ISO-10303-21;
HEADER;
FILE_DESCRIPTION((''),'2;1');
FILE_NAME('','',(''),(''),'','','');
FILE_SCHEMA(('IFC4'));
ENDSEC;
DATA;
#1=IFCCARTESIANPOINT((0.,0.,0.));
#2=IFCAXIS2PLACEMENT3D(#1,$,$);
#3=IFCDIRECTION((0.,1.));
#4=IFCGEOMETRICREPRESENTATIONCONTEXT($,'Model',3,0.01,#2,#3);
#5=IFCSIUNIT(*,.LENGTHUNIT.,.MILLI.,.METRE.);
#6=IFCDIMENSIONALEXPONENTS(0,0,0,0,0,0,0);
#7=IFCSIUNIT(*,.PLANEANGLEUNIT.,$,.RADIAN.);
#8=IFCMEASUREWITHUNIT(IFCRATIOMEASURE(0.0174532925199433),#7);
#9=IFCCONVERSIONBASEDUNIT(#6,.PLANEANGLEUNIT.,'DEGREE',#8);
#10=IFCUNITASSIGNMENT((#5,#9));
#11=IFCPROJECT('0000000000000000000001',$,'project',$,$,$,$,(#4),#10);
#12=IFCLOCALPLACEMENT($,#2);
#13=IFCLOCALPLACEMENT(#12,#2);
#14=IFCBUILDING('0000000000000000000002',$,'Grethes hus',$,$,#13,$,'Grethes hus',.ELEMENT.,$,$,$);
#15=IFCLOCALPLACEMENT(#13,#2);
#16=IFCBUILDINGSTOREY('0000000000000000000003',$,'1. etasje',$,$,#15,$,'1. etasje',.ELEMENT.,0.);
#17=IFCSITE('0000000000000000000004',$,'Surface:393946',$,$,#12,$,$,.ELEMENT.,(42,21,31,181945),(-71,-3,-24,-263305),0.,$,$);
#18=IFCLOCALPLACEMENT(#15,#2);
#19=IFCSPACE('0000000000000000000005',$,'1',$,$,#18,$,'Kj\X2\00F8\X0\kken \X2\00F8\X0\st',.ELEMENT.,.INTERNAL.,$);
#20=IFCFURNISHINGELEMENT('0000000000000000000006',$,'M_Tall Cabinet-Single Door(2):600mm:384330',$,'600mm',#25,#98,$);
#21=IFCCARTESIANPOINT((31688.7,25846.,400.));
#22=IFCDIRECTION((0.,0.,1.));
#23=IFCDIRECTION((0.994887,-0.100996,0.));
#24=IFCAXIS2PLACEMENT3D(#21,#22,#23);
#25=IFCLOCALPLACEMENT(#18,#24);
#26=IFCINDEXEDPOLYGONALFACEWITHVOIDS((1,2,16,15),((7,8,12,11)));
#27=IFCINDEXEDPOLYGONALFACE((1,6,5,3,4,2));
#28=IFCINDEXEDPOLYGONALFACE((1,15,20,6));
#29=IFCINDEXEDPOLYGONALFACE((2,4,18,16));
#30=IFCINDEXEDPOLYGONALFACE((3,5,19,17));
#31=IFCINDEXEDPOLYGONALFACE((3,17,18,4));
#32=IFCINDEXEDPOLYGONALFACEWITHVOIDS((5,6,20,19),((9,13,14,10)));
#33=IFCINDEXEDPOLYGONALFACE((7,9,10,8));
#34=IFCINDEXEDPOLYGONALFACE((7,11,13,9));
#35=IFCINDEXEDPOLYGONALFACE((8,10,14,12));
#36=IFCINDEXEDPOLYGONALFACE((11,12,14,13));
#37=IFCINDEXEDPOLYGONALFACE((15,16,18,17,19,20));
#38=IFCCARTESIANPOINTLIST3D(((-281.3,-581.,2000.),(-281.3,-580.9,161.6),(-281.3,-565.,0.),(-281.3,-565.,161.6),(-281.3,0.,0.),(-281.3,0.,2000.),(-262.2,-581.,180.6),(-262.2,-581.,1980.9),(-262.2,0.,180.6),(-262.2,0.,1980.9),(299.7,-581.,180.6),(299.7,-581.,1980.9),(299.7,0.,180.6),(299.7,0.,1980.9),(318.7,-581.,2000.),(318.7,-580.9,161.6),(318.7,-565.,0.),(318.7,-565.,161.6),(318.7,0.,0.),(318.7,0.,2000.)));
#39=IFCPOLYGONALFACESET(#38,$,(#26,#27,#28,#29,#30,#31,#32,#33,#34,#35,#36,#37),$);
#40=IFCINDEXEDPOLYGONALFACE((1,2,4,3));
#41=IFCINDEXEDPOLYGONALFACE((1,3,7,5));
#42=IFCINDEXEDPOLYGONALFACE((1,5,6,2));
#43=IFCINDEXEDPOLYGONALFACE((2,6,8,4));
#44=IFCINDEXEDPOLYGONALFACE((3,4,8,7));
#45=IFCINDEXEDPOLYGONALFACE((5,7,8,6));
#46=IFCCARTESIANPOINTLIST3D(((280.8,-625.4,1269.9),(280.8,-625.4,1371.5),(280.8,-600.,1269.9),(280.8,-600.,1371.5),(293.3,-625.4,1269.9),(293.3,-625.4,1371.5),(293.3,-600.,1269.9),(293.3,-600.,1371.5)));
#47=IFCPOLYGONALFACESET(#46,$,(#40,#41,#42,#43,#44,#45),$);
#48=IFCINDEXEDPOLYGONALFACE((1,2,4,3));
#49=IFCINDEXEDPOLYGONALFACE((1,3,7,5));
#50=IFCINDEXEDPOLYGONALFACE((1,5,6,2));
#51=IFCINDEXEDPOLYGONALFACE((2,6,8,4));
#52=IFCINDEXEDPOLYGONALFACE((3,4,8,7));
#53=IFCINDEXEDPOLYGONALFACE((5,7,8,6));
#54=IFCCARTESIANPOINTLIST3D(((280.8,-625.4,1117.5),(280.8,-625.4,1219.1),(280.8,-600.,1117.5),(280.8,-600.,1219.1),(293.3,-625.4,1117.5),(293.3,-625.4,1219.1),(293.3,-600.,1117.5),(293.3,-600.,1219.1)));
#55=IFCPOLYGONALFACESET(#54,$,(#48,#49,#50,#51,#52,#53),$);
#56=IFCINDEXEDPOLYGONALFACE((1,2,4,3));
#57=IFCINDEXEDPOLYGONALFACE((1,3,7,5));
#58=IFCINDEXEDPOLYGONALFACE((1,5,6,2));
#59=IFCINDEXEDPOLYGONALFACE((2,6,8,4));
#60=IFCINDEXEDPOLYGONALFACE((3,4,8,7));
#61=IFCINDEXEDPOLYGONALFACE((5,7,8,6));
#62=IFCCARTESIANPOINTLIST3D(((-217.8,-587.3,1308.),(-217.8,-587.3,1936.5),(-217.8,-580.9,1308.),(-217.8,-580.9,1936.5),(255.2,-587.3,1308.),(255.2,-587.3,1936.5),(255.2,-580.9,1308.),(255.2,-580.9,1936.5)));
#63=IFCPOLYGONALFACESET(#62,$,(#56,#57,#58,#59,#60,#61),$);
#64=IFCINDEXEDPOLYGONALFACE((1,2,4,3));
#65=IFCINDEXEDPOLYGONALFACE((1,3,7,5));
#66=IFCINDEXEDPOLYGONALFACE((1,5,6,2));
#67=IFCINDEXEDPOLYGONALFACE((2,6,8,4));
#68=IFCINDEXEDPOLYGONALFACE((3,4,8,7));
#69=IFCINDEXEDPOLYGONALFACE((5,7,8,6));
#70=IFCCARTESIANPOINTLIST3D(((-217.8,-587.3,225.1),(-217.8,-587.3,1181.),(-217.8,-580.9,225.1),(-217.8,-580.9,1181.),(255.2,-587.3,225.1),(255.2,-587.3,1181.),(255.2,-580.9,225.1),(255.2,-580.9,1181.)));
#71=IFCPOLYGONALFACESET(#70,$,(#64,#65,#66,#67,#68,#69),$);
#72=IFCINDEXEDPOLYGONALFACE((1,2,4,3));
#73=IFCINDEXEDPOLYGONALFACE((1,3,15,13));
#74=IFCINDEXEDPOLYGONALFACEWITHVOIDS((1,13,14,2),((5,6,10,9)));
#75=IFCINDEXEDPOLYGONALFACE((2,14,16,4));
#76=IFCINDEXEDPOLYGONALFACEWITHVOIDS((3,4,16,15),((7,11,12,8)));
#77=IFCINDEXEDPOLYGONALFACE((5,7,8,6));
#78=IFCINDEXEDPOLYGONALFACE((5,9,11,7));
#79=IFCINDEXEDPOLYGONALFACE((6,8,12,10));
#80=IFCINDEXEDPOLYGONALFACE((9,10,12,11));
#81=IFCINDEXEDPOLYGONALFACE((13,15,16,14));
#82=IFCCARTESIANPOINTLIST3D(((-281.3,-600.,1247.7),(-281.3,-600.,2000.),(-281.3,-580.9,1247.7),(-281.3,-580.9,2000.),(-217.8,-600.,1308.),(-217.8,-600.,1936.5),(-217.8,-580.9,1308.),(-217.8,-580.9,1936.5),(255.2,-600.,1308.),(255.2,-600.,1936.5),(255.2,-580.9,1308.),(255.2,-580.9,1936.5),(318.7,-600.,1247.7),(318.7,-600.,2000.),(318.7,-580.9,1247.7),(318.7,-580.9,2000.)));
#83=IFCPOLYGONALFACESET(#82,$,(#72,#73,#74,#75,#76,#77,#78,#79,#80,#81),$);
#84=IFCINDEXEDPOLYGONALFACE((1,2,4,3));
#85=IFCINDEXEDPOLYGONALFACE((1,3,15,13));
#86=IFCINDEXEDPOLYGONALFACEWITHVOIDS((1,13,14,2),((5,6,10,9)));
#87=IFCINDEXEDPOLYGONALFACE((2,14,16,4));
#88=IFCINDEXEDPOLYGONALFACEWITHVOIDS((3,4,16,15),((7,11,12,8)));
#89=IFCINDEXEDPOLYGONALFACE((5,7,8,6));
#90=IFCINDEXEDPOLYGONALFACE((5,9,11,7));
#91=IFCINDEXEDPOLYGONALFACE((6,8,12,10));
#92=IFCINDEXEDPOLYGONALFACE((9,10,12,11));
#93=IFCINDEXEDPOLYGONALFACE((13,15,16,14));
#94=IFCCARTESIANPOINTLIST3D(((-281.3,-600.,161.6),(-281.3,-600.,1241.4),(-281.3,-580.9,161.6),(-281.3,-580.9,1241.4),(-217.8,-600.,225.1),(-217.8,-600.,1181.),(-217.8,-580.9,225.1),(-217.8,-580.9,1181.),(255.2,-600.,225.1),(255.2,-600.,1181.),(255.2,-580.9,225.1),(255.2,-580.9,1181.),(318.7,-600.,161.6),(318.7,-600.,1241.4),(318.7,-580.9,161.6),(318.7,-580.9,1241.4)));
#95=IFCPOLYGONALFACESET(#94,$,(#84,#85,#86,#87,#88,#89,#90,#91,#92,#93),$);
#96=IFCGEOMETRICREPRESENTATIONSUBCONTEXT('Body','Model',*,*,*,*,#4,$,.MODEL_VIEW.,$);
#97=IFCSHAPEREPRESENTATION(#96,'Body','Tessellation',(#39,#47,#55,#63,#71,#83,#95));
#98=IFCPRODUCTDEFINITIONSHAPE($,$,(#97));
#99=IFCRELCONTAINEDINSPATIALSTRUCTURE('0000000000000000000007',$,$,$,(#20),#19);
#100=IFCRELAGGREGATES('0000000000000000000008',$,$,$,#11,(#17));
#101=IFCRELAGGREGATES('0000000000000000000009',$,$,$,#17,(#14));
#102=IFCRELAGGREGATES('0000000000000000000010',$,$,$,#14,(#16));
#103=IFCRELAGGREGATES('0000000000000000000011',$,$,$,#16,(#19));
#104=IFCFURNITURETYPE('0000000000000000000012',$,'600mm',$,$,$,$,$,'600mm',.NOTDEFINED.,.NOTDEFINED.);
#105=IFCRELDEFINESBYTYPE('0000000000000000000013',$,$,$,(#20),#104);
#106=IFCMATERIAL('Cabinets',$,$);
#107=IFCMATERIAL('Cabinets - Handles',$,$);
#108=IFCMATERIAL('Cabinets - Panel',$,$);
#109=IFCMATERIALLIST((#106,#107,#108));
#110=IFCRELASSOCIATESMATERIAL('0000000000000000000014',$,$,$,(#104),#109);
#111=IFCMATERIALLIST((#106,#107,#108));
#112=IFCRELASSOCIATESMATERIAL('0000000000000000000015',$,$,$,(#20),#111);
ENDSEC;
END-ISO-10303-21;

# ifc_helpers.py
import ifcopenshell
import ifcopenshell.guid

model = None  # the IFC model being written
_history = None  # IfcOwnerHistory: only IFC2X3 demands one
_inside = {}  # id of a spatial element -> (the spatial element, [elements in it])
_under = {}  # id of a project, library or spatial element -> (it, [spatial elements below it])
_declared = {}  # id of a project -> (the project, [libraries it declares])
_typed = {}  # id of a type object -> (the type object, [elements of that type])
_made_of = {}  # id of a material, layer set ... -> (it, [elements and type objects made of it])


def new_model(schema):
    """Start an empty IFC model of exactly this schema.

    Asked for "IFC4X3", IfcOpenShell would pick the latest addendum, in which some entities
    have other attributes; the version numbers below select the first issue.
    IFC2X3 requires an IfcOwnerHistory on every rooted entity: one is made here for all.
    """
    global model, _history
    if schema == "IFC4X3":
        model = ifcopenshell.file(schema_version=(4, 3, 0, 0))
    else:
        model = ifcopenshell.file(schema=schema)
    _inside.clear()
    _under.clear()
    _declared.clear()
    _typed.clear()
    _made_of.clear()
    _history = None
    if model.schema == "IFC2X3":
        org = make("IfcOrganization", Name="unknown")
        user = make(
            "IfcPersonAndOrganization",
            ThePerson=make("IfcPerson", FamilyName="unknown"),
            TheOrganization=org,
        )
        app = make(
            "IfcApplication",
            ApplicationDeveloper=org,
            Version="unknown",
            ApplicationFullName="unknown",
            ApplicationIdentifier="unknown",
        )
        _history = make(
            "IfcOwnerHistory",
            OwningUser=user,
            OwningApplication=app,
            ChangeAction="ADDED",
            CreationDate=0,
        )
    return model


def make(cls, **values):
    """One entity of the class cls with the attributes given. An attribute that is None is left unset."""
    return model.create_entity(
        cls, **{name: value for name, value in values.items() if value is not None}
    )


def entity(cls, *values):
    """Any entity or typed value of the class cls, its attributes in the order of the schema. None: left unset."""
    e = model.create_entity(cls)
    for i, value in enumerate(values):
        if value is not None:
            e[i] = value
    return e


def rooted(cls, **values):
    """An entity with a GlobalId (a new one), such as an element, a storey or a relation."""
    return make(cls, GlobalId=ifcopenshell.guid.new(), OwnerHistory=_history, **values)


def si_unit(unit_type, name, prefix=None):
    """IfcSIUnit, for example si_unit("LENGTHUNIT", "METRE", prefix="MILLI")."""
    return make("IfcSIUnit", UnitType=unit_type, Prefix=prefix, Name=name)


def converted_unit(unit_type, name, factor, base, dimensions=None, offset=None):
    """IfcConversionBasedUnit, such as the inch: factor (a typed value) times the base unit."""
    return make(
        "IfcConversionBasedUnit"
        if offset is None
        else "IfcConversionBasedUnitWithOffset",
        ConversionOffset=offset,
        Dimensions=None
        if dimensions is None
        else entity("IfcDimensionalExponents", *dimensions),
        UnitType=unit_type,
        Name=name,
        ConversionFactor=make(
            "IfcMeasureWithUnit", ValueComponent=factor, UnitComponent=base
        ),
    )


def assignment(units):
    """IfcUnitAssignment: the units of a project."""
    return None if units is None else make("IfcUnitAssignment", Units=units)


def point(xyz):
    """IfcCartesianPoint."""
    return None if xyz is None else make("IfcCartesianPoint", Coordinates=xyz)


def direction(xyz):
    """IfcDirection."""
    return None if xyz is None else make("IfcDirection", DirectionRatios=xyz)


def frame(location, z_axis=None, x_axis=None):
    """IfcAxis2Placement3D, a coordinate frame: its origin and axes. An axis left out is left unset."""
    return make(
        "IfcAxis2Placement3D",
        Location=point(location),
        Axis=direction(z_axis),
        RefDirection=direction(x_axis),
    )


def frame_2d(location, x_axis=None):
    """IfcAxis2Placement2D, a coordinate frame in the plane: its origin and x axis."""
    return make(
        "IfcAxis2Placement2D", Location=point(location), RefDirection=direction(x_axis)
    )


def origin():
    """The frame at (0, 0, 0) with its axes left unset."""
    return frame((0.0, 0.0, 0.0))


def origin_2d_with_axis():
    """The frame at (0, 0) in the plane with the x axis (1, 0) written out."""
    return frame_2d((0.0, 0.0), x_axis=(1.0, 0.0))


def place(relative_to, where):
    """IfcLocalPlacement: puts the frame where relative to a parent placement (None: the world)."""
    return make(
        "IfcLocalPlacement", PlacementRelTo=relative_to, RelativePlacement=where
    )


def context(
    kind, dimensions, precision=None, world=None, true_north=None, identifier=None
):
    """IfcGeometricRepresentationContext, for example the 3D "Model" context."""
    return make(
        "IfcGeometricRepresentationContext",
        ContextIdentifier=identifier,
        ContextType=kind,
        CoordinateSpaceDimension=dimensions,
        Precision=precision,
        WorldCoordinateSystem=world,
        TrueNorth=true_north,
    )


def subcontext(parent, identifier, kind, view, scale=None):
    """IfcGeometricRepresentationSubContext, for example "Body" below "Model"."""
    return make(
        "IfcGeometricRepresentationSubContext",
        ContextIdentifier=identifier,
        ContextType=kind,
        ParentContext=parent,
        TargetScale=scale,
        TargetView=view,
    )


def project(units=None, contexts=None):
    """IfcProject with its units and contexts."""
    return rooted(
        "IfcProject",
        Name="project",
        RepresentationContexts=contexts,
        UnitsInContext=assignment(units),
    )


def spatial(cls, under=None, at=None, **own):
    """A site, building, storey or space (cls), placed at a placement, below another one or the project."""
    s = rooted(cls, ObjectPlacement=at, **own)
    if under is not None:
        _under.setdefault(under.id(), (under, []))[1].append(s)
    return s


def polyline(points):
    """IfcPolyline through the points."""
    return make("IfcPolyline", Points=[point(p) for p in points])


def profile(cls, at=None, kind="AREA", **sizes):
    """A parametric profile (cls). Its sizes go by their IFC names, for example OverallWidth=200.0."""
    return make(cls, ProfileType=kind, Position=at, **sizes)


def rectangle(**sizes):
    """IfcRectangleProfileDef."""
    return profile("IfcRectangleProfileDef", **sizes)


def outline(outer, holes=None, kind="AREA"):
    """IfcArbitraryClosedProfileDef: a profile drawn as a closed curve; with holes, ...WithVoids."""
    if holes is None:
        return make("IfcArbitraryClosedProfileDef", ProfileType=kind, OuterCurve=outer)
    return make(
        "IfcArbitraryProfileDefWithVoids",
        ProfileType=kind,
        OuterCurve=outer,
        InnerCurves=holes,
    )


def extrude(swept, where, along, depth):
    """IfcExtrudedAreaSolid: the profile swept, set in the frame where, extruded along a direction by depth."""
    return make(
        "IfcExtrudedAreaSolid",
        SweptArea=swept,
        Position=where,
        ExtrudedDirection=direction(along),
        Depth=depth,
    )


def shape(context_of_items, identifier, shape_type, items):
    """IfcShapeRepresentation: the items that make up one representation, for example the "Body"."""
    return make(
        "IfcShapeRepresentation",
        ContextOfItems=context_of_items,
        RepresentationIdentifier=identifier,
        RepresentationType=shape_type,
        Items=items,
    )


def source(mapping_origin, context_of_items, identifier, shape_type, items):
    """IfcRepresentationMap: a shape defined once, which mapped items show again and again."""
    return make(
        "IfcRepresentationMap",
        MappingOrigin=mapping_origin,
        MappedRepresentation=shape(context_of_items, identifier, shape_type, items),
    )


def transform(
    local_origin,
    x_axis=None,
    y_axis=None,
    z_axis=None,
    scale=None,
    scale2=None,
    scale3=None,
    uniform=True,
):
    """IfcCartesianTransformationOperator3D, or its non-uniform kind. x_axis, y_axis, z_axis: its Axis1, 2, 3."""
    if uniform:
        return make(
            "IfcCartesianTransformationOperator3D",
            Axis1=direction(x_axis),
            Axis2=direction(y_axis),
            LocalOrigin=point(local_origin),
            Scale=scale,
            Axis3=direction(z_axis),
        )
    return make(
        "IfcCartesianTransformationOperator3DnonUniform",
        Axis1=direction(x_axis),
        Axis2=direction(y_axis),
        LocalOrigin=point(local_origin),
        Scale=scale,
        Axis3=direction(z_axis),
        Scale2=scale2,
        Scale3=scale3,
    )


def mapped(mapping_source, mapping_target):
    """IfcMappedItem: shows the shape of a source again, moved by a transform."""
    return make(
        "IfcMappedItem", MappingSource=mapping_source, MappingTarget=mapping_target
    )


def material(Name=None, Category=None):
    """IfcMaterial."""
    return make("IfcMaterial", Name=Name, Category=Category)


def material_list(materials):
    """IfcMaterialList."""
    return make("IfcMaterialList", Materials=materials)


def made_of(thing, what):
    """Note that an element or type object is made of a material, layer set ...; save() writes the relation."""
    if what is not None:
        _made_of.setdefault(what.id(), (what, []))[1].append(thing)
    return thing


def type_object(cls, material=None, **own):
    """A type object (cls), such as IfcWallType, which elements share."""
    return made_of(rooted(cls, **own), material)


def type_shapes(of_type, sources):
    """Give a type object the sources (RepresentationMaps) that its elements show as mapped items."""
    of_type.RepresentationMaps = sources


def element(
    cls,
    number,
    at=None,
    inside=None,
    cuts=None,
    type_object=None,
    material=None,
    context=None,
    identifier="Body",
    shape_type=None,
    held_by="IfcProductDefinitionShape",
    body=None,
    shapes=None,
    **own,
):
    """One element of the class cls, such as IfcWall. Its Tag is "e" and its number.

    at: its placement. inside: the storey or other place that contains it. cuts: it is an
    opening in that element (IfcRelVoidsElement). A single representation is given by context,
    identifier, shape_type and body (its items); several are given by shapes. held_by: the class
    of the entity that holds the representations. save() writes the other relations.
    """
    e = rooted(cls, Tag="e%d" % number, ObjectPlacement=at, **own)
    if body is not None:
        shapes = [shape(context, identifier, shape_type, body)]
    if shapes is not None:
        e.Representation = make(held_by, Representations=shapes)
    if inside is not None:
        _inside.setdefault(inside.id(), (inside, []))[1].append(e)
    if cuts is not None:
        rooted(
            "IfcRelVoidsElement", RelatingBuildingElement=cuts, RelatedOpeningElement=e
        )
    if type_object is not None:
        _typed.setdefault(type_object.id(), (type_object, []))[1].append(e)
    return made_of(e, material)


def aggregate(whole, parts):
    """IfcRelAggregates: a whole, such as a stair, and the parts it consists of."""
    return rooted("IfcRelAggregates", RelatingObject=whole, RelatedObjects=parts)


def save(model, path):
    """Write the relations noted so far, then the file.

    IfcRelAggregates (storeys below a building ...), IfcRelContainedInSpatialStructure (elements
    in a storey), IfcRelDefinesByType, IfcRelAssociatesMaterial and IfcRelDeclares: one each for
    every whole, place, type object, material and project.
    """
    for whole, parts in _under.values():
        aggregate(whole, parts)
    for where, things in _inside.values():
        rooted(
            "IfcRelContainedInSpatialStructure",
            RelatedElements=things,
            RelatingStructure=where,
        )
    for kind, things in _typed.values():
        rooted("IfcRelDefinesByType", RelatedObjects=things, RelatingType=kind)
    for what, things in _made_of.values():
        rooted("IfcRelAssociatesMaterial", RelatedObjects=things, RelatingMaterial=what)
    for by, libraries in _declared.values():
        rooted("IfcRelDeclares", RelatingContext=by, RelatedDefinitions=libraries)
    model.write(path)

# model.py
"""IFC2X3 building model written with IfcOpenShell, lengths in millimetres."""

from ifc_helpers import new_model, entity, si_unit, converted_unit, direction, frame, frame_2d, origin, origin_2d_with_axis, place, context, subcontext, project, spatial, polyline, rectangle, outline, extrude, source, transform, mapped, material, material_list, type_object, type_shapes, element, save


model = new_model("IFC2X3")

# Units and contexts
model_context = context("Model", 3, precision=0.01, world=origin(), true_north=direction((0.0, 1.0)))
body_context = subcontext(model_context, "Body", "Model", "MODEL_VIEW")
ifc_project = project(units=[si_unit("LENGTHUNIT", "METRE", prefix="MILLI"), converted_unit("PLANEANGLEUNIT", "DEGREE", entity("IfcRatioMeasure", 0.0174532925199433), si_unit("PLANEANGLEUNIT", "RADIAN"), dimensions=[0, 0, 0, 0, 0, 0, 0])], contexts=[model_context])

# Site, building, storey
site_placement = place(None, origin())
site = spatial("IfcSite", under=ifc_project, at=site_placement, Name="Surface:393946", CompositionType="ELEMENT", RefLatitude=(42, 21, 31, 181945), RefLongitude=(-71, -3, -24, -263305), RefElevation=0.0)
building_placement = place(site_placement, origin())
building = spatial("IfcBuilding", under=site, at=building_placement, Name="Grethes hus", LongName="Grethes hus", CompositionType="ELEMENT")
storey_placement = place(building_placement, origin())
storey = spatial("IfcBuildingStorey", under=building, at=storey_placement, Name="1. etasje", LongName="1. etasje", CompositionType="ELEMENT", Elevation=0.0)

# Shared definitions
space_placement = place(storey_placement, origin())
space = spatial("IfcSpace", under=storey, at=space_placement, Name="1", LongName="Kjøkken øst", CompositionType="ELEMENT", InteriorOrExteriorSpace="INTERNAL")

# Furnishing element, opening
ifc_material_1 = material(Name="Cabinets")
ifc_material_2 = material(Name="Cabinets - Handles")
ifc_material_3 = material(Name="Cabinets - Panel")
ifc_material_list_1 = material_list([ifc_material_1, ifc_material_2, ifc_material_3])
ifc_material_list_2 = material_list([ifc_material_1, ifc_material_2, ifc_material_3])
furniture_type_1 = type_object("IfcFurnitureType", Name="600mm", ElementType="600mm", material=ifc_material_list_2)
shared_shape_1 = source(origin(), body_context, "Body", "SweptSolid", [
    extrude(outline(polyline([(-199.0, 558.9), (-199.0, -1279.5), (382.0, -1279.5), (382.0, 720.5), (-183.0, 720.5), (-183.0, 558.9), (-199.0, 558.9)])), frame((-281.3, -382.0, 720.5), z_axis=(-1.0, 0.0, 0.0), x_axis=(0.0, 1.0, 0.0)), (0.0, 0.0, -1.0), 600.0),
    extrude(rectangle(XDim=25.4, YDim=12.5, at=frame_2d((0.0, 0.0), x_axis=(1.0, 0.0))), frame((287.1, -612.7, 1269.9), z_axis=(0.0, 0.0, 1.0), x_axis=(0.0, 1.0, 0.0)), (0.0, 0.0, 1.0), 101.6),
    extrude(rectangle(XDim=25.4, YDim=12.5, at=frame_2d((0.0, 0.0), x_axis=(1.0, 0.0))), frame((287.1, -612.7, 1117.5), z_axis=(0.0, 0.0, 1.0), x_axis=(0.0, 1.0, 0.0)), (0.0, 0.0, 1.0), 101.6),
    extrude(rectangle(XDim=6.3, YDim=473.0, at=frame_2d((0.0, 0.0), x_axis=(1.0, 0.0))), frame((18.7, -584.1, 1308.0), z_axis=(0.0, 0.0, 1.0), x_axis=(0.0, 1.0, 0.0)), (0.0, 0.0, 1.0), 628.5),
    extrude(rectangle(XDim=6.3, YDim=473.0, at=frame_2d((0.0, 0.0), x_axis=(1.0, 0.0))), frame((18.7, -584.1, 225.1), z_axis=(0.0, 0.0, 1.0), x_axis=(0.0, 1.0, 0.0)), (0.0, 0.0, 1.0), 956.0),
    extrude(outline(polyline([(-376.1, -300.0), (376.1, -300.0), (376.1, 300.0), (-376.1, 300.0), (-376.1, -300.0)]), holes=[polyline([(-312.6, -236.5), (-312.6, 236.5), (315.8, 236.5), (315.8, -236.5), (-312.6, -236.5)])]), frame((18.7, -600.0, 1623.9), z_axis=(0.0, 1.0, 0.0), x_axis=(0.0, 0.0, -1.0)), (0.0, 0.0, 1.0), 19.1),
    extrude(outline(polyline([(-300.0, -539.9), (300.0, -539.9), (300.0, 539.9), (-300.0, 539.9), (-300.0, -539.9)]), holes=[polyline([(-236.5, 479.6), (236.5, 479.6), (236.5, -476.4), (-236.5, -476.4), (-236.5, 479.6)])]), frame((18.7, -600.0, 701.5), z_axis=(0.0, 1.0, 0.0), x_axis=(-1.0, 0.0, 0.0)), (0.0, 0.0, 1.0), 19.1),
    extrude(rectangle(XDim=19.1, YDim=561.9, at=origin_2d_with_axis()), frame((18.7, -9.5, 180.6), z_axis=(0.0, 0.0, 1.0), x_axis=(0.0, 1.0, 0.0)), (0.0, 0.0, 1.0), 1800.3),
])
type_shapes(furniture_type_1, [shared_shape_1])
furnishing_1_placement = place(space_placement, frame((31688.7, 25846.0, 400.0), z_axis=(0.0, 0.0, 1.0), x_axis=(0.994887, -0.100996, 0.0)))
furnishing_1 = element("IfcFurnishingElement", 1, at=furnishing_1_placement, inside=space, type_object=furniture_type_1, material=ifc_material_list_1, Name="M_Tall Cabinet-Single Door(2):600mm:384330", ObjectType="600mm", context=body_context, shape_type="MappedRepresentation", body=[
    mapped(shared_shape_1, transform((0.0, 0.0, 0.0), scale=1.0)),
])
opening_1_placement = place(storey_placement, frame((31688.7, 25846.0, 400.0), z_axis=(0.0, 0.0, 1.0), x_axis=(0.9796, -0.200959, 0.0)))
element("IfcOpeningElement", 2, at=opening_1_placement, cuts=furnishing_1, ObjectType="Opening", context=body_context, shape_type="SweptSolid", body=[
    extrude(rectangle(XDim=1800.3, YDim=561.9, at=frame_2d((0.0, 0.0), x_axis=(1.0, 0.0))), frame((77.3, -576.1, 1080.8), z_axis=(-0.100996, 0.994887, 0.0), x_axis=(0.0, 0.0, -1.0)), (0.0, 0.0, 1.0), 580.9),
])

save(model, "model.ifc")
